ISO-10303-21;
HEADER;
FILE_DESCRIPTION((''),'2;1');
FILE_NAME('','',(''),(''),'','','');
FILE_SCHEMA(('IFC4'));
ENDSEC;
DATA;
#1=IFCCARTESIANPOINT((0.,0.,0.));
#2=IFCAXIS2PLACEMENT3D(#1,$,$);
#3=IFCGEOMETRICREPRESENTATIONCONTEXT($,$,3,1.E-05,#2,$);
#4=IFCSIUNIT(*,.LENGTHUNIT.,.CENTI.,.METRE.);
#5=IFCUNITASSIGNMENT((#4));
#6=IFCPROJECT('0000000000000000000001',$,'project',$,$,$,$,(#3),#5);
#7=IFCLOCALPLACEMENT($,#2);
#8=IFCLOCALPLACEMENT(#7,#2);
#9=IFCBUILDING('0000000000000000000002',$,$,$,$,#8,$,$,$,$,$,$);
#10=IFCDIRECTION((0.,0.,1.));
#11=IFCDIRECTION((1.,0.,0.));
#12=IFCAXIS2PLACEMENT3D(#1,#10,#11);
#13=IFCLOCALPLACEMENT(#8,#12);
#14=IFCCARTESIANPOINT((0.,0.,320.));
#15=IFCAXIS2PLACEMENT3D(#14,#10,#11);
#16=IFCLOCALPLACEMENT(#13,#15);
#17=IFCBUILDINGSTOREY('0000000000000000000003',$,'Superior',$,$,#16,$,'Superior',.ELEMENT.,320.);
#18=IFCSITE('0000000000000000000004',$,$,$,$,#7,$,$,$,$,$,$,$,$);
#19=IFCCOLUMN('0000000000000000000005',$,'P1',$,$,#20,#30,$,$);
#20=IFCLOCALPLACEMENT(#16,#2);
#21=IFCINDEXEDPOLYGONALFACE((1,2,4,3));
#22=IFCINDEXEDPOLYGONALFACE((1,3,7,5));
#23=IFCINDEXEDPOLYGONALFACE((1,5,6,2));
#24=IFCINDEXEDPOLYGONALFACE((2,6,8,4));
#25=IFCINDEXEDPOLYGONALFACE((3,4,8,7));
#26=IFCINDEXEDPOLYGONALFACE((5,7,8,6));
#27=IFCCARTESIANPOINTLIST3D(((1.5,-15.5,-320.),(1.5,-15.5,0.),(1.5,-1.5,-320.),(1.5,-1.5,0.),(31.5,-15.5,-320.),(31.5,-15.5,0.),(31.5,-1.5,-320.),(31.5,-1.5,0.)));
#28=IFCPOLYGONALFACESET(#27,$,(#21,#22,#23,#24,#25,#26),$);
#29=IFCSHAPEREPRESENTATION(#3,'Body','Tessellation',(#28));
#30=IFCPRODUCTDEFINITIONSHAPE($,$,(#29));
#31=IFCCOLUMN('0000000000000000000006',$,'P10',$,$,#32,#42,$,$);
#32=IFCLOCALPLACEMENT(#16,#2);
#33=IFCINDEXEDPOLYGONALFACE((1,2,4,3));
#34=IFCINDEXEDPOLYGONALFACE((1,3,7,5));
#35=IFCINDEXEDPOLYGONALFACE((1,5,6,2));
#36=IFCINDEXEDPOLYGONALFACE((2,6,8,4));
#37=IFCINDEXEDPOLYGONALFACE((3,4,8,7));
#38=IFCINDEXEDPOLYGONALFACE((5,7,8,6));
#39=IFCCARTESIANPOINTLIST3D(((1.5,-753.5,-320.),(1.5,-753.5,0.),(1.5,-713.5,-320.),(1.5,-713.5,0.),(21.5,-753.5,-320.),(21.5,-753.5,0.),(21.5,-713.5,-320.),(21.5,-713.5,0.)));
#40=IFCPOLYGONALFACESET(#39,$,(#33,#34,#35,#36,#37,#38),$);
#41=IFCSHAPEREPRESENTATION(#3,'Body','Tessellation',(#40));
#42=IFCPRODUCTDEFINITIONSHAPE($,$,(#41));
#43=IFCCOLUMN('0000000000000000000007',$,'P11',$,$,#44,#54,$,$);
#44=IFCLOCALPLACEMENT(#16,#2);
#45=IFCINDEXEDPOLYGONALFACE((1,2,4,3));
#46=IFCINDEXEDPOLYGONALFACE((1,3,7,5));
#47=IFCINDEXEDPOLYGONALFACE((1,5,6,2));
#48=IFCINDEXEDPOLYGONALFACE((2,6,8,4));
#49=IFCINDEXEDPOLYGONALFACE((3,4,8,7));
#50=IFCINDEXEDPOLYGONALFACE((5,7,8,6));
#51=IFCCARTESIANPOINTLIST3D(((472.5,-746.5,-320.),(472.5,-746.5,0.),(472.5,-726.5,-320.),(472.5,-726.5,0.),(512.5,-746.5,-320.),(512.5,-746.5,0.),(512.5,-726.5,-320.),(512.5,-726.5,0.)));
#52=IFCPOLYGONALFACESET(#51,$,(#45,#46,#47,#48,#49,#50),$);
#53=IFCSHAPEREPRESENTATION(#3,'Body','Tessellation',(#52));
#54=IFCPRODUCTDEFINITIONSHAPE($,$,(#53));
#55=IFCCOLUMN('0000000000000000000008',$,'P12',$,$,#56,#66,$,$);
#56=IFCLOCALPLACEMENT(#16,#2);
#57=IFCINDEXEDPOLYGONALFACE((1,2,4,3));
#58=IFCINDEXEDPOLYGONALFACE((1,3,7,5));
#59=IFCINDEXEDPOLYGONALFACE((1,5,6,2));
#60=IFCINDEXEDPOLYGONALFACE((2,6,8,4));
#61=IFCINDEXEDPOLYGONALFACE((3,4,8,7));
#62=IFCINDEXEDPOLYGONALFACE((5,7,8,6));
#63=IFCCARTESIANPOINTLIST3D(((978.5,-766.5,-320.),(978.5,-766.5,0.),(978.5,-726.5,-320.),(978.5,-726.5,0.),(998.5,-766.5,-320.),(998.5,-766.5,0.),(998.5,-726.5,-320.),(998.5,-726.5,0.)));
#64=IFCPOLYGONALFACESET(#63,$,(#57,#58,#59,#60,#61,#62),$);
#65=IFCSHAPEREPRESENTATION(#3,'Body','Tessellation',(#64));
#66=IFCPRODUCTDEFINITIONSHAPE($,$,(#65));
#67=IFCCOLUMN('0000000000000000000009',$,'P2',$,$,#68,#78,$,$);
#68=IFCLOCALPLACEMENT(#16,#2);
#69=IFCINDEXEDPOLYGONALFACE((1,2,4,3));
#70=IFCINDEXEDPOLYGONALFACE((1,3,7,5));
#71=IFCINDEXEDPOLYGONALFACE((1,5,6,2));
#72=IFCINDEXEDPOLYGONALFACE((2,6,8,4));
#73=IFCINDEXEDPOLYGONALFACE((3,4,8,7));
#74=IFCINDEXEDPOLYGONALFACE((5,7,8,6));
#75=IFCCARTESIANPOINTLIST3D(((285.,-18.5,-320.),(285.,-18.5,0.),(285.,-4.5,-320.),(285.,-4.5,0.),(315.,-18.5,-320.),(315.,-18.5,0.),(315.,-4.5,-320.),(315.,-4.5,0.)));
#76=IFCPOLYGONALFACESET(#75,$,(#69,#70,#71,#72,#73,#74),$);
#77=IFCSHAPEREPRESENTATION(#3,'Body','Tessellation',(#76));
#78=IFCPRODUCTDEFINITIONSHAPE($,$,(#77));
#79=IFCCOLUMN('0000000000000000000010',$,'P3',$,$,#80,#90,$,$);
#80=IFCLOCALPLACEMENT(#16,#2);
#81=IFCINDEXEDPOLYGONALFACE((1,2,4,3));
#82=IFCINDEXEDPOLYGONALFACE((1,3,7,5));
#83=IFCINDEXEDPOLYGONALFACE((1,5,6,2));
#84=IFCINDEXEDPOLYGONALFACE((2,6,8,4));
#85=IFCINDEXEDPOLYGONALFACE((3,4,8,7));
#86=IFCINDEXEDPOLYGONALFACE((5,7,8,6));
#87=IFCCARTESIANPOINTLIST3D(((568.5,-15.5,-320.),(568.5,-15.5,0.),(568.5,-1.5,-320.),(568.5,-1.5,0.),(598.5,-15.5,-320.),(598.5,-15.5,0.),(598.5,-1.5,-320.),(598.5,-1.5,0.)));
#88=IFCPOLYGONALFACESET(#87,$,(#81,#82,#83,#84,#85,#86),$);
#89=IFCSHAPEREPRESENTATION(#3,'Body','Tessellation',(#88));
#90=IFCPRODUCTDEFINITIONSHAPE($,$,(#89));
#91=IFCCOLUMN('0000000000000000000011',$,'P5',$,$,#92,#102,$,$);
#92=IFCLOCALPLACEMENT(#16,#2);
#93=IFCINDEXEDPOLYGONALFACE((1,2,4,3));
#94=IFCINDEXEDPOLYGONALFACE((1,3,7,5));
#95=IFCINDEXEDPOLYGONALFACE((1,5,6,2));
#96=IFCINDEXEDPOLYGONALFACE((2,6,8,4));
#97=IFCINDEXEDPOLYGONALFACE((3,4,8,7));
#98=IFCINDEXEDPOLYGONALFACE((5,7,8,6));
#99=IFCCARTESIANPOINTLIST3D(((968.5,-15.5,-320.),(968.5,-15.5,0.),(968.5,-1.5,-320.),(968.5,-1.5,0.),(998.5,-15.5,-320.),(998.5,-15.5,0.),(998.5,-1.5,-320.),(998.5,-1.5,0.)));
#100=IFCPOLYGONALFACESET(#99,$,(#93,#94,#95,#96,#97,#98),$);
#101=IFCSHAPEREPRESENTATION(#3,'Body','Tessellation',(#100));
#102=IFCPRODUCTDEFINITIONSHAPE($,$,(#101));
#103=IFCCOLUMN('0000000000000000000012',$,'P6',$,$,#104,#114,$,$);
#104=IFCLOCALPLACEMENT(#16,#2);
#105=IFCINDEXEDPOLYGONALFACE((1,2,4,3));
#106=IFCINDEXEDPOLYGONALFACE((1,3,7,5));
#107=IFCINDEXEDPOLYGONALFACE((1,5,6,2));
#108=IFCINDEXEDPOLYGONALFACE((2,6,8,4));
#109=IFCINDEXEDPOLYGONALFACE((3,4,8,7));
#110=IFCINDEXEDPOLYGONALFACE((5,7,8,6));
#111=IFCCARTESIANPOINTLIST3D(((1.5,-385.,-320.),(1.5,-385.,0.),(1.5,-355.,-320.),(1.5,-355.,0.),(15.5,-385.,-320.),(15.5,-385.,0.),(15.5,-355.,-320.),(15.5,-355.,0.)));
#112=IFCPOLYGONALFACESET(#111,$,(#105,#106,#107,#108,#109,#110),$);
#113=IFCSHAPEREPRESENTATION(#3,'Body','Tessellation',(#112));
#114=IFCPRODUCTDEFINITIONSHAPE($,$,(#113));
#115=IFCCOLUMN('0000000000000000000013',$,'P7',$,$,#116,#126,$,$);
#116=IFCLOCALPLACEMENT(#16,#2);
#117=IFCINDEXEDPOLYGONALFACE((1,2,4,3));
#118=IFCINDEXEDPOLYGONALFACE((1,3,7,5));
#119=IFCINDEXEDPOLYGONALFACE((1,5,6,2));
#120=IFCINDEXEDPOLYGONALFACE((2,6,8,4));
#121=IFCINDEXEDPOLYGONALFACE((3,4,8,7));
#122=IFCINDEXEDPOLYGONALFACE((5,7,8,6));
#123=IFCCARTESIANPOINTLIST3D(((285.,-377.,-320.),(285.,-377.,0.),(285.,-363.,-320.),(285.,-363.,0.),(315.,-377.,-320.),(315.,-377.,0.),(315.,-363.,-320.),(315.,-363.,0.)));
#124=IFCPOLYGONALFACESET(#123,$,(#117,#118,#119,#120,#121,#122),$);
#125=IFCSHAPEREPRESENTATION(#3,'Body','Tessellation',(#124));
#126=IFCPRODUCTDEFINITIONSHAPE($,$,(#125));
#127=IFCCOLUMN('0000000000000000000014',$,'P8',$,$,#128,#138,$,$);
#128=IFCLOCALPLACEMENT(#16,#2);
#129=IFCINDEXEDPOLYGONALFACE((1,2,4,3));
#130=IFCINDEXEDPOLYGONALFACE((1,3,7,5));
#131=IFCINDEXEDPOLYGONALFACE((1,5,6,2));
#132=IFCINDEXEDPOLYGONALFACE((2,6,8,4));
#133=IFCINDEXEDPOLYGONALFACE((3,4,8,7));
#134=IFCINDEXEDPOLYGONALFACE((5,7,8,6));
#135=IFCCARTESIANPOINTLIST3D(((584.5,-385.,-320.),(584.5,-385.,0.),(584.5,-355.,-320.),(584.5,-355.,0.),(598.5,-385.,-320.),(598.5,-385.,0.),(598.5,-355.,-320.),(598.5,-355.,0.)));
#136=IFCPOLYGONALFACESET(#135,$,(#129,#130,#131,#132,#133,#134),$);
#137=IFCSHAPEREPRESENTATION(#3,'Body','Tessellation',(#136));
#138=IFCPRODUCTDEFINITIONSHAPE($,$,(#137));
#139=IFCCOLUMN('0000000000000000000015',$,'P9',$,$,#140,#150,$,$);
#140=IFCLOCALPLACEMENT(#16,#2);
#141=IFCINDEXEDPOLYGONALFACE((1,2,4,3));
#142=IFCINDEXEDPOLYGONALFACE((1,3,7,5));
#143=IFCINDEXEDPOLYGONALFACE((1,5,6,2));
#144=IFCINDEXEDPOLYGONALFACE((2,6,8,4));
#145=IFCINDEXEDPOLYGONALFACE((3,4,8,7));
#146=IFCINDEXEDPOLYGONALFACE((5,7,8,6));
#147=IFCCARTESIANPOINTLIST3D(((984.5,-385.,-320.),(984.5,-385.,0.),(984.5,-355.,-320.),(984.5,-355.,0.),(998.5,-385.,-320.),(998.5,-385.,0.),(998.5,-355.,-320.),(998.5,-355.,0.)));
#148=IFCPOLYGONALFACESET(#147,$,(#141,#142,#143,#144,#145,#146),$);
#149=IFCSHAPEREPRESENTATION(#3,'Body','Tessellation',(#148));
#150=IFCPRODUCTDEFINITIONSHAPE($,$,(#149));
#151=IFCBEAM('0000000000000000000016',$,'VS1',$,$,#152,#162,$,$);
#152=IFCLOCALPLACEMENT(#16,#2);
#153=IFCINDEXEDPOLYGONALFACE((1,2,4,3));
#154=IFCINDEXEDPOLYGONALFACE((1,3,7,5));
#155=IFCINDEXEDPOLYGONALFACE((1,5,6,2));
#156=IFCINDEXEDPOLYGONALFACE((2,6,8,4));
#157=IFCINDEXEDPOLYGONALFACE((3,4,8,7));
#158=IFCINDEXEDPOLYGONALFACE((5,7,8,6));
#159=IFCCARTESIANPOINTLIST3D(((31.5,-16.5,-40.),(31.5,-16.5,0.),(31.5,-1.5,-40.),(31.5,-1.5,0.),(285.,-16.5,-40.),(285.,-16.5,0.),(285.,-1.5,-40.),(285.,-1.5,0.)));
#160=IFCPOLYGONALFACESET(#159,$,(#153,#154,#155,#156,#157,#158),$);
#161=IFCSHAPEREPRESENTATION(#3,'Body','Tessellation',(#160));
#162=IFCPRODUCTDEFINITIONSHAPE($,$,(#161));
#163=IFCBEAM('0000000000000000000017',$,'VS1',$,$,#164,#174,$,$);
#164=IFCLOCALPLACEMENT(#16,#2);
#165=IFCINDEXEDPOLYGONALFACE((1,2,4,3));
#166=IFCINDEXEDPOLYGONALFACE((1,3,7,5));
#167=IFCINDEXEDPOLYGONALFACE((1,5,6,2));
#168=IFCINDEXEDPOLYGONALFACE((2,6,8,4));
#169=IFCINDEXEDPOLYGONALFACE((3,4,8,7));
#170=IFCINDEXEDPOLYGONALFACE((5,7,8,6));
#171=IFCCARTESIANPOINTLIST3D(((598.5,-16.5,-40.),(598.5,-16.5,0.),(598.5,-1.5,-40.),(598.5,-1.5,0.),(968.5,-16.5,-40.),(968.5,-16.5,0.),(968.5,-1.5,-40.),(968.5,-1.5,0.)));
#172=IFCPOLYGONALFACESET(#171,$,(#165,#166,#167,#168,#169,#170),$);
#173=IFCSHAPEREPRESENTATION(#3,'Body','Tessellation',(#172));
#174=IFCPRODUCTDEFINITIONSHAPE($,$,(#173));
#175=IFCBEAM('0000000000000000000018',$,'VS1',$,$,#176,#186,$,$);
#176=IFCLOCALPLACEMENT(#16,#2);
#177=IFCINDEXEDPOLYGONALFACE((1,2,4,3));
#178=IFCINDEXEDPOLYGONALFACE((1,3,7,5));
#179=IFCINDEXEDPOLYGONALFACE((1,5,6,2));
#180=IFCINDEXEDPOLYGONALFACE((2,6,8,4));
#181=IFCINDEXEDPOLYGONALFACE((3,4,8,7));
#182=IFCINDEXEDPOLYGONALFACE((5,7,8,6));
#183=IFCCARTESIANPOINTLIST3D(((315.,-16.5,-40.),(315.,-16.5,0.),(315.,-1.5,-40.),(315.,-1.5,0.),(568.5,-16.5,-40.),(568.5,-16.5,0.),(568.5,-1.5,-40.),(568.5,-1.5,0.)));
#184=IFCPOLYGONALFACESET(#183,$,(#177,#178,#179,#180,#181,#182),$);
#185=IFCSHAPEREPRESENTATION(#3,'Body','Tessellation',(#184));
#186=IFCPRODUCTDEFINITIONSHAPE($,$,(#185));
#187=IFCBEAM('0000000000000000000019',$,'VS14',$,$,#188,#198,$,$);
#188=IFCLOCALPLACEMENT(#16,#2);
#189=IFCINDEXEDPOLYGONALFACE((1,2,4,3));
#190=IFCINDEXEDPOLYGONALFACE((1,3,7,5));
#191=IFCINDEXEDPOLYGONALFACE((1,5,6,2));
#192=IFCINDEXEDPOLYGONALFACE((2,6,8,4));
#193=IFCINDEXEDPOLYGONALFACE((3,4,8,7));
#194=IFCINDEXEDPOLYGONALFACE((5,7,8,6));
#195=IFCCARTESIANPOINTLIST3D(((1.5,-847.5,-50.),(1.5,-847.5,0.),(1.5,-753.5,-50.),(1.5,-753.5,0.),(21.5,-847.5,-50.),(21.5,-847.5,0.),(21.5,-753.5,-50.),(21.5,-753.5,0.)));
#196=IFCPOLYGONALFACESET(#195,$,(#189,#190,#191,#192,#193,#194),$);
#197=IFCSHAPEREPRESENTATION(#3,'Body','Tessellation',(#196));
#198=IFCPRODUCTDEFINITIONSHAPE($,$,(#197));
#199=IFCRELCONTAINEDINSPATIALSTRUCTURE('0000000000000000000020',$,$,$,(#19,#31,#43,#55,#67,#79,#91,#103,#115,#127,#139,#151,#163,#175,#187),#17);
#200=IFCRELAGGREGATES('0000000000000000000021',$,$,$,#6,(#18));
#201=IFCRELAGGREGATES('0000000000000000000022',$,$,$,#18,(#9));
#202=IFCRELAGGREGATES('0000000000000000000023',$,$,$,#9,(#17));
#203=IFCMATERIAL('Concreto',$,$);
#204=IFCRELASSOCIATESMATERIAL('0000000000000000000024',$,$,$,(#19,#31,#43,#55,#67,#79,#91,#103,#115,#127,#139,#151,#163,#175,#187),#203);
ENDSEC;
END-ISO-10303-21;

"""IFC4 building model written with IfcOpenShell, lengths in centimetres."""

from ifc_helpers import new_model, si_unit, frame, origin, origin_with_axes, place, context, project, spatial, polyline, outline, extrude, material, element, save


model = new_model("IFC4")

# Units and contexts
context_of_model = context(None, 3, precision=1e-05, world=origin())
ifc_project = project(units=[si_unit("LENGTHUNIT", "METRE", prefix="CENTI")], contexts=[context_of_model])

# Site, building, storey
site_placement = place(None, origin())
site = spatial("IfcSite", under=ifc_project, at=site_placement)
building_placement = place(site_placement, origin())
building = spatial("IfcBuilding", under=site, at=building_placement)
placement = place(building_placement, origin_with_axes())
storey_placement = place(placement, frame((0.0, 0.0, 320.0), z_axis=(0.0, 0.0, 1.0), x_axis=(1.0, 0.0, 0.0)))
storey = spatial("IfcBuildingStorey", under=building, at=storey_placement, Name="Superior", LongName="Superior", CompositionType="ELEMENT", Elevation=320.0)

# Columns
ifc_material = material(Name="Concreto")
column_1_placement = place(storey_placement, frame((16.5, -8.5, 0.0), z_axis=(0.0, 0.0, 1.0), x_axis=(1.0, 0.0, 0.0)))
element("IfcColumn", 1, at=column_1_placement, inside=storey, material=ifc_material, Name="P1", context=context_of_model, shape_type="SolidModel", body=[
    extrude(outline(polyline([(-15.0, 7.0), (-15.0, -7.0), (15.0, -7.0), (15.0, 7.0), (-15.0, 7.0)])), frame((0.0, 0.0, 0.0), z_axis=(0.0, 0.0, 1.0), x_axis=(1.0, 0.0, 0.0)), (0.0, 0.0, -1.0), 320.0),
])
column_2_placement = place(storey_placement, frame((11.5, -733.5, 0.0), z_axis=(0.0, 0.0, 1.0), x_axis=(1.0, 0.0, 0.0)))
element("IfcColumn", 2, at=column_2_placement, inside=storey, material=ifc_material, Name="P10", context=context_of_model, shape_type="SolidModel", body=[
    extrude(outline(polyline([(10.0, 20.0), (-10.0, 20.0), (-10.0, -20.0), (10.0, -20.0), (10.0, 20.0)])), frame((0.0, 0.0, 0.0), z_axis=(0.0, 0.0, 1.0), x_axis=(1.0, 0.0, 0.0)), (0.0, 0.0, -1.0), 320.0),
])
column_3_placement = place(storey_placement, frame((492.5, -736.5, 0.0), z_axis=(0.0, 0.0, 1.0), x_axis=(1.0, 0.0, 0.0)))
element("IfcColumn", 3, at=column_3_placement, inside=storey, material=ifc_material, Name="P11", context=context_of_model, shape_type="SolidModel", body=[
    extrude(outline(polyline([(-20.0, 10.0), (-20.0, -10.0), (20.0, -10.0), (20.0, 10.0), (-20.0, 10.0)])), origin_with_axes(), (0.0, 0.0, -1.0), 320.0),
])
column_4_placement = place(storey_placement, frame((988.5, -746.5, 0.0), z_axis=(0.0, 0.0, 1.0), x_axis=(1.0, 0.0, 0.0)))
element("IfcColumn", 4, at=column_4_placement, inside=storey, material=ifc_material, Name="P12", context=context_of_model, shape_type="SolidModel", body=[
    extrude(outline(polyline([(-10.0, -20.0), (10.0, -20.0), (10.0, 20.0), (-10.0, 20.0), (-10.0, -20.0)])), origin_with_axes(), (0.0, 0.0, -1.0), 320.0),
])
column_5_placement = place(storey_placement, frame((300.0, -11.5, 0.0), z_axis=(0.0, 0.0, 1.0), x_axis=(1.0, 0.0, 0.0)))
element("IfcColumn", 5, at=column_5_placement, inside=storey, material=ifc_material, Name="P2", context=context_of_model, shape_type="SolidModel", body=[
    extrude(outline(polyline([(15.0, -7.0), (15.0, 7.0), (-15.0, 7.0), (-15.0, -7.0), (15.0, -7.0)])), frame((0.0, 0.0, 0.0), z_axis=(0.0, 0.0, 1.0), x_axis=(1.0, 0.0, 0.0)), (0.0, 0.0, -1.0), 320.0),
])
for number, where, z_axis, x_axis, name in (
    (6, (583.5, -8.5, 0.0), (0.0, 0.0, 1.0), (1.0, 0.0, 0.0), "P3"),
    (7, (983.5, -8.5, 0.0), (0.0, 0.0, 1.0), (1.0, 0.0, 0.0), "P5"),
):
    element("IfcColumn", number, at=place(storey_placement, frame(where, z_axis=z_axis, x_axis=x_axis)), inside=storey, material=ifc_material, Name=name, context=context_of_model, shape_type="SolidModel", body=[
        extrude(outline(polyline([(-15.0, 7.0), (-15.0, -7.0), (15.0, -7.0), (15.0, 7.0), (-15.0, 7.0)])), origin_with_axes(), (0.0, 0.0, -1.0), 320.0),
    ])
column_6_placement = place(storey_placement, frame((8.5, -370.0, 0.0), z_axis=(0.0, 0.0, 1.0), x_axis=(1.0, 0.0, 0.0)))
element("IfcColumn", 8, at=column_6_placement, inside=storey, material=ifc_material, Name="P6", context=context_of_model, shape_type="SolidModel", body=[
    extrude(outline(polyline([(-7.0, -15.0), (7.0, -15.0), (7.0, 15.0), (-7.0, 15.0), (-7.0, -15.0)])), frame((0.0, 0.0, 0.0), z_axis=(0.0, 0.0, 1.0), x_axis=(1.0, 0.0, 0.0)), (0.0, 0.0, -1.0), 320.0),
])
column_7_placement = place(storey_placement, frame((300.0, -370.0, 0.0), z_axis=(0.0, 0.0, 1.0), x_axis=(1.0, 0.0, 0.0)))
element("IfcColumn", 9, at=column_7_placement, inside=storey, material=ifc_material, Name="P7", context=context_of_model, shape_type="SolidModel", body=[
    extrude(outline(polyline([(15.0, -7.0), (15.0, 7.0), (-15.0, 7.0), (-15.0, -7.0), (15.0, -7.0)])), origin_with_axes(), (0.0, 0.0, -1.0), 320.0),
])
for number, where, z_axis, x_axis, name in (
    (10, (591.5, -370.0, 0.0), (0.0, 0.0, 1.0), (1.0, 0.0, 0.0), "P8"),
    (11, (991.5, -370.0, 0.0), (0.0, 0.0, 1.0), (1.0, 0.0, 0.0), "P9"),
):
    element("IfcColumn", number, at=place(storey_placement, frame(where, z_axis=z_axis, x_axis=x_axis)), inside=storey, material=ifc_material, Name=name, context=context_of_model, shape_type="SolidModel", body=[
        extrude(outline(polyline([(7.0, 15.0), (-7.0, 15.0), (-7.0, -15.0), (7.0, -15.0), (7.0, 15.0)])), origin_with_axes(), (0.0, 0.0, -1.0), 320.0),
    ])

# Beams
beam_1_placement = place(storey_placement, frame((158.25, -9.0, 0.0), z_axis=(0.0, 0.0, 1.0), x_axis=(1.0, 0.0, 0.0)))
element("IfcBeam", 12, at=beam_1_placement, inside=storey, material=ifc_material, Name="VS1", context=context_of_model, shape_type="SolidModel", body=[
    extrude(outline(polyline([(7.5, 20.0), (-7.5, 20.0), (-7.5, -20.0), (7.5, -20.0), (7.5, 20.0)])), frame((-126.75, 0.0, -20.0), z_axis=(1.0, 0.0, 0.0), x_axis=(0.0, 1.0, 0.0)), (0.0, 0.0, 1.0), 253.5),
])
beam_2_placement = place(storey_placement, frame((783.5, -9.0, 0.0), z_axis=(0.0, 0.0, 1.0), x_axis=(1.0, 0.0, 0.0)))
element("IfcBeam", 13, at=beam_2_placement, inside=storey, material=ifc_material, Name="VS1", context=context_of_model, shape_type="SolidModel", body=[
    extrude(outline(polyline([(7.5, 20.0), (-7.5, 20.0), (-7.5, -20.0), (7.5, -20.0), (7.5, 20.0)])), frame((-185.0, 0.0, -20.0), z_axis=(1.0, 0.0, 0.0), x_axis=(0.0, 1.0, 0.0)), (0.0, 0.0, 1.0), 370.0),
])
beam_3_placement = place(storey_placement, frame((441.75, -9.0, 0.0), z_axis=(0.0, 0.0, 1.0), x_axis=(1.0, 0.0, 0.0)))
element("IfcBeam", 14, at=beam_3_placement, inside=storey, material=ifc_material, Name="VS1", context=context_of_model, shape_type="SolidModel", body=[
    extrude(outline(polyline([(7.5, 20.0), (-7.5, 20.0), (-7.5, -20.0), (7.5, -20.0), (7.5, 20.0)])), frame((-126.75, 0.0, -20.0), z_axis=(1.0, 0.0, 0.0), x_axis=(0.0, 1.0, 0.0)), (0.0, 0.0, 1.0), 253.5),
])
beam_4_placement = place(storey_placement, frame((11.5, -800.5, 0.0), z_axis=(0.0, 0.0, 1.0), x_axis=(1.0, 0.0, 0.0)))
element("IfcBeam", 15, at=beam_4_placement, inside=storey, material=ifc_material, Name="VS14", context=context_of_model, shape_type="SolidModel", body=[
    extrude(outline(polyline([(-10.0, -25.0), (10.0, -25.0), (10.0, 25.0), (-10.0, 25.0), (-10.0, -25.0)])), frame((0.0, -47.0, -25.0), z_axis=(0.0, 1.0, 0.0), x_axis=(1.0, 0.0, 0.0)), (0.0, 0.0, 1.0), 94.0),
])

save(model, "model.ifc")
